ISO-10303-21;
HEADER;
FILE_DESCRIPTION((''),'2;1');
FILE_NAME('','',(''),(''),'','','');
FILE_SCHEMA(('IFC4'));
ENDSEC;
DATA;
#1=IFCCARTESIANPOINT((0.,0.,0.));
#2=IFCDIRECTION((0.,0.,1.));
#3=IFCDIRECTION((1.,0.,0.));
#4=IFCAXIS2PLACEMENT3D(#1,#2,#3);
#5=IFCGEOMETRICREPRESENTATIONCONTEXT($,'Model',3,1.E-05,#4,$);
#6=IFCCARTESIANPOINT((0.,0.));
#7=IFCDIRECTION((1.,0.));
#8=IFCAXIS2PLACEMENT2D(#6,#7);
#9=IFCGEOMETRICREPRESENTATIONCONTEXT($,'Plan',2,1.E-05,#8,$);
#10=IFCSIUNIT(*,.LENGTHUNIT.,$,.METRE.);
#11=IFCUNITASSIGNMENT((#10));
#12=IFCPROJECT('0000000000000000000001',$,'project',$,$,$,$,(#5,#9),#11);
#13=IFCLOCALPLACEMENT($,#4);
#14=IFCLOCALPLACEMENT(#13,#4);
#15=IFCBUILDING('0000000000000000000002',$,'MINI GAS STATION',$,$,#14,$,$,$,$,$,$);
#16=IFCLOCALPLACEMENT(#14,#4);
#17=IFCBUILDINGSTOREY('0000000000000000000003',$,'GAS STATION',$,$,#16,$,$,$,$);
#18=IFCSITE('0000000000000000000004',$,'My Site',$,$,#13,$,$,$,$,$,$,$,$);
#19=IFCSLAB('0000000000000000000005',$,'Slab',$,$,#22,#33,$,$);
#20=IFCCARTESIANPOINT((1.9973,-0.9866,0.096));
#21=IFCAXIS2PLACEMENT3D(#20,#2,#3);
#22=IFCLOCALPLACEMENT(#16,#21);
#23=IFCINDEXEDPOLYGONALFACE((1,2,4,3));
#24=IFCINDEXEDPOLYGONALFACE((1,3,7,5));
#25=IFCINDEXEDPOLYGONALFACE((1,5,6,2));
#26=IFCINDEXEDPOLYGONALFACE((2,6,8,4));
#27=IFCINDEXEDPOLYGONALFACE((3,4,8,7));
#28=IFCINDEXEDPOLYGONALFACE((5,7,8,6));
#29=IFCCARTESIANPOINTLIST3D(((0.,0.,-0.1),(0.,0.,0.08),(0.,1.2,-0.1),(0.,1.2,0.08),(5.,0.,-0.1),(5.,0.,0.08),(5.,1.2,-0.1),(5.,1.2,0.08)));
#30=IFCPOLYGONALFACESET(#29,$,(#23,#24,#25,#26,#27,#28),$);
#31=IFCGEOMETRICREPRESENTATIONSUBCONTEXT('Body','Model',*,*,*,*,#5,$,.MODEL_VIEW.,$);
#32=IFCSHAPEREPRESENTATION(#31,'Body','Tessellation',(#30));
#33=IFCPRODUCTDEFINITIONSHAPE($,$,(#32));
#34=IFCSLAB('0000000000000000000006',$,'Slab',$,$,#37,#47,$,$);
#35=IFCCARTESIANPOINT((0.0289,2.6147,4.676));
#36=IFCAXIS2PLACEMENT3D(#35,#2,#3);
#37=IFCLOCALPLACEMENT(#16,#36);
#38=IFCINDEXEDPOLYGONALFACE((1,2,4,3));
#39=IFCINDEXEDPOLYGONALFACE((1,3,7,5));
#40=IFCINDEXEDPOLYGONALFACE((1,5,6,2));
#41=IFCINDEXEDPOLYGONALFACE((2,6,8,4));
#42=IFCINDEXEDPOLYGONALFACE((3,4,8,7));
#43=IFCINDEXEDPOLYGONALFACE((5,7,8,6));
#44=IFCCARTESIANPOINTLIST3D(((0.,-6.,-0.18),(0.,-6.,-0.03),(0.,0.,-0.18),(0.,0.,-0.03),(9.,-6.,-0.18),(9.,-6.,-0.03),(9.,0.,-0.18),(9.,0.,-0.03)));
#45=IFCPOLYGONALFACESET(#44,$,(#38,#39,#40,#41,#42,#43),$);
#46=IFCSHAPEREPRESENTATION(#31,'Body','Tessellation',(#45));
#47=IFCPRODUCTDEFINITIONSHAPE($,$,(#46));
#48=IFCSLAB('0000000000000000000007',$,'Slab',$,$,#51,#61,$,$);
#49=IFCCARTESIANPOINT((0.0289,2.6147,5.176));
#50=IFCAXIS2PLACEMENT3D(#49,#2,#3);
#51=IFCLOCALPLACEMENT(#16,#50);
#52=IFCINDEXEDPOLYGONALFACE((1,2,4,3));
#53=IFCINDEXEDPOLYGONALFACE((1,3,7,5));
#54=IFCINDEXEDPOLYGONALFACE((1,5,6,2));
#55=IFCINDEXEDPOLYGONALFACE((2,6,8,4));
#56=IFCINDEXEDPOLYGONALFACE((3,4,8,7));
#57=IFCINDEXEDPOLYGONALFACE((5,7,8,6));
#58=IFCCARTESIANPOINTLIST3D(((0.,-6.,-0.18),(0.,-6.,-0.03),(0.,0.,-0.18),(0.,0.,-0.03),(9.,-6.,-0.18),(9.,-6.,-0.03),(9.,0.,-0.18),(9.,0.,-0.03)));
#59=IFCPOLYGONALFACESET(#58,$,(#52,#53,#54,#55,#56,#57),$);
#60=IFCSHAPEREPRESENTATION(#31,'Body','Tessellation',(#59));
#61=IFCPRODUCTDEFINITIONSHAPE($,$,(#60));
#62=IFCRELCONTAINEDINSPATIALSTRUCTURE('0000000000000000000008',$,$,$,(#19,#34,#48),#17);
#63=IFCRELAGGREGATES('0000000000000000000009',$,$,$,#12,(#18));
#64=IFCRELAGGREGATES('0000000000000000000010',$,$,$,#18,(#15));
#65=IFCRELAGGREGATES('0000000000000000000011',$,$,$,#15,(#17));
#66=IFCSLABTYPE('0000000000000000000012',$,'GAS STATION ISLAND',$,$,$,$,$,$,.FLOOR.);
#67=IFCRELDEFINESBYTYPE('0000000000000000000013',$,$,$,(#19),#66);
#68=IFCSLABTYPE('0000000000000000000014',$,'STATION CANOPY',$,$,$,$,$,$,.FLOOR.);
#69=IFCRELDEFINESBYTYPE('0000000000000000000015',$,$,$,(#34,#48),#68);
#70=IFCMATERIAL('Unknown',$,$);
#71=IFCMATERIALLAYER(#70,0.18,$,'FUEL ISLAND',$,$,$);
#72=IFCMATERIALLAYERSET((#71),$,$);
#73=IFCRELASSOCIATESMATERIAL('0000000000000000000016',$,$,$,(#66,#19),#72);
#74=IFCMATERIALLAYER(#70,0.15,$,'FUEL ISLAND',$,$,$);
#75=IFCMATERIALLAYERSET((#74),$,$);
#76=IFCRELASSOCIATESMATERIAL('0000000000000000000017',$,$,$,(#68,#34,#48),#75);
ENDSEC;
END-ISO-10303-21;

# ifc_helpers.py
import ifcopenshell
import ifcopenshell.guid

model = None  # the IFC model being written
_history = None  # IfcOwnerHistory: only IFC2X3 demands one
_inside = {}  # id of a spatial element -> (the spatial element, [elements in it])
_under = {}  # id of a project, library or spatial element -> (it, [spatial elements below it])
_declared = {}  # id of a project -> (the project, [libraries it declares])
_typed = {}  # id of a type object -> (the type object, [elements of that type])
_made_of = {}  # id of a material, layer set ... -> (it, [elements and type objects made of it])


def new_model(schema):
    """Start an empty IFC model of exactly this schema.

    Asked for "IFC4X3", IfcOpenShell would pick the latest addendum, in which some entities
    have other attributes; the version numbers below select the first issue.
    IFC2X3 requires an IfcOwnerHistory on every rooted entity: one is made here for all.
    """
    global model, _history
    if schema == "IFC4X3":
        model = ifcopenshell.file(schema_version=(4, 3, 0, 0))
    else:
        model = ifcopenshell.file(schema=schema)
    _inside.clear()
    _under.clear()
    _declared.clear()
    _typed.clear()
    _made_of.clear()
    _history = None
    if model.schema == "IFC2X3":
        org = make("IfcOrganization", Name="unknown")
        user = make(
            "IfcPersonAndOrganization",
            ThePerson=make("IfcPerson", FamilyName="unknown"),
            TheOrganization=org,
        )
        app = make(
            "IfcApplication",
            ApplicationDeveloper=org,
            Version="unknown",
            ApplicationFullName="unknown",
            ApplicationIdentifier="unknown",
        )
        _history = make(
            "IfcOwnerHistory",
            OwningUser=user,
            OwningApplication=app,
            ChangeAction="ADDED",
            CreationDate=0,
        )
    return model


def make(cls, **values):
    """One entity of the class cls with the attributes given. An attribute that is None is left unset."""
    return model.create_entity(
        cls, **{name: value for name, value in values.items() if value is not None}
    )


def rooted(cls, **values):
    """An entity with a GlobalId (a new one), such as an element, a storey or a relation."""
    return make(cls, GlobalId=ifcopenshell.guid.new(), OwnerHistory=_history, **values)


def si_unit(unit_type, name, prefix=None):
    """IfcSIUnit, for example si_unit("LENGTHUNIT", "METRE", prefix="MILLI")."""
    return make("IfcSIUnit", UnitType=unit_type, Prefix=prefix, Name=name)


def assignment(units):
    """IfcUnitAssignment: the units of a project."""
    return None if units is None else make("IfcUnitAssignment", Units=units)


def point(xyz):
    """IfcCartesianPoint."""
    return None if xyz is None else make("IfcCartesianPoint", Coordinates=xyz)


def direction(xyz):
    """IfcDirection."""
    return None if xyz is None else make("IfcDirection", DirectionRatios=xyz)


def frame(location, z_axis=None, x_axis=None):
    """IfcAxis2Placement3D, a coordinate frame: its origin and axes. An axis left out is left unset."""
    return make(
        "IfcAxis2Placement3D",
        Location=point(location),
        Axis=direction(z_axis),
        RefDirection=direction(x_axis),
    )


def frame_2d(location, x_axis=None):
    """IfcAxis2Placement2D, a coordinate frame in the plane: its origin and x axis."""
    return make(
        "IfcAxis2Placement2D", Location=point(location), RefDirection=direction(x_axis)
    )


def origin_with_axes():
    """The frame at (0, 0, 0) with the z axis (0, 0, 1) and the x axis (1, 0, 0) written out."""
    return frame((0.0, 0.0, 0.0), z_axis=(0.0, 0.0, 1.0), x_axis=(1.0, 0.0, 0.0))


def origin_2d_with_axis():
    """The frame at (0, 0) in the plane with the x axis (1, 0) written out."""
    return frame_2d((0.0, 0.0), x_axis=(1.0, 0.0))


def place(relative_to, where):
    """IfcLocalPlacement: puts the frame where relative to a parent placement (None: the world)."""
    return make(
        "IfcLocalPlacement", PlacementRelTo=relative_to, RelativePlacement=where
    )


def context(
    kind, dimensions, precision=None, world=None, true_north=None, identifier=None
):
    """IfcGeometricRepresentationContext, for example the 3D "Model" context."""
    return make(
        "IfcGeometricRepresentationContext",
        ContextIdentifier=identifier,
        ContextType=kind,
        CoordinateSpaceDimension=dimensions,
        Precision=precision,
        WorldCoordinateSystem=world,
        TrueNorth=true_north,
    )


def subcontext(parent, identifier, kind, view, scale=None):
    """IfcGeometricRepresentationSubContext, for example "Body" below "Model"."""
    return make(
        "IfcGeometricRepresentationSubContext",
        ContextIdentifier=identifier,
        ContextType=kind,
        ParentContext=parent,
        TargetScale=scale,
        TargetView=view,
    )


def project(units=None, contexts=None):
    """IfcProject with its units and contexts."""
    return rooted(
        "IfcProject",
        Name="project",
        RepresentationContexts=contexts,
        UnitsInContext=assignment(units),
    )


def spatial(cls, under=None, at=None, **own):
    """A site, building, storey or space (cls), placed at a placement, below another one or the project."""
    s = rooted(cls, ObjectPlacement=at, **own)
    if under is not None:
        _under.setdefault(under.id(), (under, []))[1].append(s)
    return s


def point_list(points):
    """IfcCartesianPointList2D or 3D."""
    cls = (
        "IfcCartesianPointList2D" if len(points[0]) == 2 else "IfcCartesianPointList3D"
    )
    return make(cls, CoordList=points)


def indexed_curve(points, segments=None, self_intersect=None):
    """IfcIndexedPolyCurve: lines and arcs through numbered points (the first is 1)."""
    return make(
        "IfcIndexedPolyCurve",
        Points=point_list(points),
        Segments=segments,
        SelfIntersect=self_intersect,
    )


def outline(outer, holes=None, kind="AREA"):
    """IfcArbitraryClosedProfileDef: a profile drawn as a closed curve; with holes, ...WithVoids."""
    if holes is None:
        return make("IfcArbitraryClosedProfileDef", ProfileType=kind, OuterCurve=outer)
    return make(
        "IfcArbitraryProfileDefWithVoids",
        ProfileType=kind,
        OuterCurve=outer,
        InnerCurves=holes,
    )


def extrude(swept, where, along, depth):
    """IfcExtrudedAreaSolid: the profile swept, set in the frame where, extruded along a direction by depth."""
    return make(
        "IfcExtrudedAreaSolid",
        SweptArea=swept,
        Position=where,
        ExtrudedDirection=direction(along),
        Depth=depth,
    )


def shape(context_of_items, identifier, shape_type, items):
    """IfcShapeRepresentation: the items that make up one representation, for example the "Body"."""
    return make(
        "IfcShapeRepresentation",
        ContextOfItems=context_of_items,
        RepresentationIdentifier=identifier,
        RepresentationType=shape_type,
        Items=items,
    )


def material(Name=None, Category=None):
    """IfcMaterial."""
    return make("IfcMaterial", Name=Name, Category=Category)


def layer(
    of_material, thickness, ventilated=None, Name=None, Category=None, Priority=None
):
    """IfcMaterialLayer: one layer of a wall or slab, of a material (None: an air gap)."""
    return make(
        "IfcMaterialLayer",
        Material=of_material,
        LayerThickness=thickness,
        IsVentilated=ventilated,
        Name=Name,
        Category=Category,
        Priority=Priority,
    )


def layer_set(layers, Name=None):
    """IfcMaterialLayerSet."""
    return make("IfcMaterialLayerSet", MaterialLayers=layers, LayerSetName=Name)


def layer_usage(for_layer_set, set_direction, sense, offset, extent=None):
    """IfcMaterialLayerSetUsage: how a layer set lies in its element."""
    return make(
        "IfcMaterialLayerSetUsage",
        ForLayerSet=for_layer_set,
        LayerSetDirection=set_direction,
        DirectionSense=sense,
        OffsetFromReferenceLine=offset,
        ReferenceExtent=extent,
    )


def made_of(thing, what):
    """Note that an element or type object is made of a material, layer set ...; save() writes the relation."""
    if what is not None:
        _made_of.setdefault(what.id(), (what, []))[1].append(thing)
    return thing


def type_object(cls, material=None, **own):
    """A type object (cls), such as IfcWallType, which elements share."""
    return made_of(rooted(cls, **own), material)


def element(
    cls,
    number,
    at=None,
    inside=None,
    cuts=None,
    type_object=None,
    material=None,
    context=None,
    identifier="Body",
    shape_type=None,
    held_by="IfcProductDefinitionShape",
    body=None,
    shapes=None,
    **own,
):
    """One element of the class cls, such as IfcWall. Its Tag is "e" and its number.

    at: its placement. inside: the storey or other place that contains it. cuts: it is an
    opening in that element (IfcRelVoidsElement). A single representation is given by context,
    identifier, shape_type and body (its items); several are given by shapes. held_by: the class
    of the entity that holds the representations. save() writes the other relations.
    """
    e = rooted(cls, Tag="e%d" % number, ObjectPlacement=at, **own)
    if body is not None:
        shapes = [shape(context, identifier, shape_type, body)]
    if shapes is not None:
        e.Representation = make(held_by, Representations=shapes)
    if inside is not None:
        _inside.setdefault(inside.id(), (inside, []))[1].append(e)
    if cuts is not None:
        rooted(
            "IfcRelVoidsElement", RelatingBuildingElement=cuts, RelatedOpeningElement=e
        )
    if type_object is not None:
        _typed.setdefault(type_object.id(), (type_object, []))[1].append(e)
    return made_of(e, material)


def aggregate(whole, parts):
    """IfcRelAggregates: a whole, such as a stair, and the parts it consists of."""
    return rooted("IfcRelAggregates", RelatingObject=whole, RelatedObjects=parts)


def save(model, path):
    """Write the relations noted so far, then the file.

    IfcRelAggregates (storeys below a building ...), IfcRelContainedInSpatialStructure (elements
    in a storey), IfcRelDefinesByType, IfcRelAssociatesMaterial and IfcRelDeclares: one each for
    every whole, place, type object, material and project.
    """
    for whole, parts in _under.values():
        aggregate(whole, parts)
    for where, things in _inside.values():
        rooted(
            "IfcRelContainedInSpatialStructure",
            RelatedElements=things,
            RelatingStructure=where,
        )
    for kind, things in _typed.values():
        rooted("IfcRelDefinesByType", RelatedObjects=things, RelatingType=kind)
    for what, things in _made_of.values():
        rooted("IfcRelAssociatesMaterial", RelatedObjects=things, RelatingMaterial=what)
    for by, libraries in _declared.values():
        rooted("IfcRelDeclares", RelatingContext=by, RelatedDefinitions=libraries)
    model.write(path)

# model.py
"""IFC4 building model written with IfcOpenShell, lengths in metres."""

from ifc_helpers import new_model, si_unit, frame, origin_with_axes, origin_2d_with_axis, place, context, subcontext, project, spatial, indexed_curve, outline, extrude, material, layer, layer_set, layer_usage, type_object, element, save


model = new_model("IFC4")

# Units and contexts
model_context = context("Model", 3, precision=1e-05, world=origin_with_axes())
plan_context = context("Plan", 2, precision=1e-05, world=origin_2d_with_axis())
body_context = subcontext(model_context, "Body", "Model", "MODEL_VIEW")
ifc_project = project(units=[si_unit("LENGTHUNIT", "METRE")], contexts=[model_context, plan_context])

# Site, building, storey
site_placement = place(None, origin_with_axes())
site = spatial("IfcSite", under=ifc_project, at=site_placement, Name="My Site")
building_placement = place(site_placement, origin_with_axes())
building = spatial("IfcBuilding", under=site, at=building_placement, Name="MINI GAS STATION")
storey_placement = place(building_placement, origin_with_axes())
storey = spatial("IfcBuildingStorey", under=building, at=storey_placement, Name="GAS STATION")

# Shared definitions
ifc_material = material(Name="Unknown")

# Slabs
ifc_layer_1 = layer(ifc_material, 0.18, Name="FUEL ISLAND")
ifc_layer_set_1 = layer_set([ifc_layer_1])
ifc_layer_usage_1 = layer_usage(ifc_layer_set_1, "AXIS3", "POSITIVE", -0.1)
slab_type_1 = type_object("IfcSlabType", Name="GAS STATION ISLAND", PredefinedType="FLOOR", material=ifc_layer_set_1)
slab_1_placement = place(storey_placement, frame((1.9973, -0.9866, 0.096), z_axis=(0.0, 0.0, 1.0), x_axis=(1.0, 0.0, 0.0)))
element("IfcSlab", 1, at=slab_1_placement, inside=storey, type_object=slab_type_1, material=ifc_layer_usage_1, Name="Slab", context=body_context, shape_type="SweptSolid", body=[
    extrude(outline(indexed_curve([(0.0, 0.0), (5.0, 0.0), (5.0, 1.2), (0.0, 1.2), (0.0, 0.0)])), frame((0.0, 0.0, -0.1), z_axis=(0.0, 0.0, 1.0), x_axis=(1.0, 0.0, 0.0)), (0.0, 0.0, 1.0), 0.18),
])
ifc_layer_2 = layer(ifc_material, 0.15, Name="FUEL ISLAND")
ifc_layer_set_2 = layer_set([ifc_layer_2])
ifc_layer_usage_2 = layer_usage(ifc_layer_set_2, "AXIS3", "POSITIVE", -0.18)
slab_type_2 = type_object("IfcSlabType", Name="STATION CANOPY", PredefinedType="FLOOR", material=ifc_layer_set_2)
slab_2_placement = place(storey_placement, frame((0.0289, 2.6147, 4.676), z_axis=(0.0, 0.0, 1.0), x_axis=(1.0, 0.0, 0.0)))
element("IfcSlab", 2, at=slab_2_placement, inside=storey, type_object=slab_type_2, material=ifc_layer_usage_2, Name="Slab", context=body_context, shape_type="SweptSolid", body=[
    extrude(outline(indexed_curve([(0.0, 0.0), (9.0, 0.0), (9.0, -6.0), (0.0, -6.0), (0.0, 0.0)])), frame((0.0, 0.0, -0.18), z_axis=(0.0, 0.0, 1.0), x_axis=(1.0, 0.0, 0.0)), (0.0, 0.0, 1.0), 0.15),
])
ifc_layer_usage_3 = layer_usage(ifc_layer_set_2, "AXIS3", "POSITIVE", -0.18)
slab_3_placement = place(storey_placement, frame((0.0289, 2.6147, 5.176), z_axis=(0.0, 0.0, 1.0), x_axis=(1.0, 0.0, 0.0)))
element("IfcSlab", 3, at=slab_3_placement, inside=storey, type_object=slab_type_2, material=ifc_layer_usage_3, Name="Slab", context=body_context, shape_type="SweptSolid", body=[
    extrude(outline(indexed_curve([(0.0, 0.0), (9.0, 0.0), (9.0, -6.0), (0.0, -6.0), (0.0, 0.0)])), frame((0.0, 0.0, -0.18), z_axis=(0.0, 0.0, 1.0), x_axis=(1.0, 0.0, 0.0)), (0.0, 0.0, 1.0), 0.15),
])

save(model, "model.ifc")
